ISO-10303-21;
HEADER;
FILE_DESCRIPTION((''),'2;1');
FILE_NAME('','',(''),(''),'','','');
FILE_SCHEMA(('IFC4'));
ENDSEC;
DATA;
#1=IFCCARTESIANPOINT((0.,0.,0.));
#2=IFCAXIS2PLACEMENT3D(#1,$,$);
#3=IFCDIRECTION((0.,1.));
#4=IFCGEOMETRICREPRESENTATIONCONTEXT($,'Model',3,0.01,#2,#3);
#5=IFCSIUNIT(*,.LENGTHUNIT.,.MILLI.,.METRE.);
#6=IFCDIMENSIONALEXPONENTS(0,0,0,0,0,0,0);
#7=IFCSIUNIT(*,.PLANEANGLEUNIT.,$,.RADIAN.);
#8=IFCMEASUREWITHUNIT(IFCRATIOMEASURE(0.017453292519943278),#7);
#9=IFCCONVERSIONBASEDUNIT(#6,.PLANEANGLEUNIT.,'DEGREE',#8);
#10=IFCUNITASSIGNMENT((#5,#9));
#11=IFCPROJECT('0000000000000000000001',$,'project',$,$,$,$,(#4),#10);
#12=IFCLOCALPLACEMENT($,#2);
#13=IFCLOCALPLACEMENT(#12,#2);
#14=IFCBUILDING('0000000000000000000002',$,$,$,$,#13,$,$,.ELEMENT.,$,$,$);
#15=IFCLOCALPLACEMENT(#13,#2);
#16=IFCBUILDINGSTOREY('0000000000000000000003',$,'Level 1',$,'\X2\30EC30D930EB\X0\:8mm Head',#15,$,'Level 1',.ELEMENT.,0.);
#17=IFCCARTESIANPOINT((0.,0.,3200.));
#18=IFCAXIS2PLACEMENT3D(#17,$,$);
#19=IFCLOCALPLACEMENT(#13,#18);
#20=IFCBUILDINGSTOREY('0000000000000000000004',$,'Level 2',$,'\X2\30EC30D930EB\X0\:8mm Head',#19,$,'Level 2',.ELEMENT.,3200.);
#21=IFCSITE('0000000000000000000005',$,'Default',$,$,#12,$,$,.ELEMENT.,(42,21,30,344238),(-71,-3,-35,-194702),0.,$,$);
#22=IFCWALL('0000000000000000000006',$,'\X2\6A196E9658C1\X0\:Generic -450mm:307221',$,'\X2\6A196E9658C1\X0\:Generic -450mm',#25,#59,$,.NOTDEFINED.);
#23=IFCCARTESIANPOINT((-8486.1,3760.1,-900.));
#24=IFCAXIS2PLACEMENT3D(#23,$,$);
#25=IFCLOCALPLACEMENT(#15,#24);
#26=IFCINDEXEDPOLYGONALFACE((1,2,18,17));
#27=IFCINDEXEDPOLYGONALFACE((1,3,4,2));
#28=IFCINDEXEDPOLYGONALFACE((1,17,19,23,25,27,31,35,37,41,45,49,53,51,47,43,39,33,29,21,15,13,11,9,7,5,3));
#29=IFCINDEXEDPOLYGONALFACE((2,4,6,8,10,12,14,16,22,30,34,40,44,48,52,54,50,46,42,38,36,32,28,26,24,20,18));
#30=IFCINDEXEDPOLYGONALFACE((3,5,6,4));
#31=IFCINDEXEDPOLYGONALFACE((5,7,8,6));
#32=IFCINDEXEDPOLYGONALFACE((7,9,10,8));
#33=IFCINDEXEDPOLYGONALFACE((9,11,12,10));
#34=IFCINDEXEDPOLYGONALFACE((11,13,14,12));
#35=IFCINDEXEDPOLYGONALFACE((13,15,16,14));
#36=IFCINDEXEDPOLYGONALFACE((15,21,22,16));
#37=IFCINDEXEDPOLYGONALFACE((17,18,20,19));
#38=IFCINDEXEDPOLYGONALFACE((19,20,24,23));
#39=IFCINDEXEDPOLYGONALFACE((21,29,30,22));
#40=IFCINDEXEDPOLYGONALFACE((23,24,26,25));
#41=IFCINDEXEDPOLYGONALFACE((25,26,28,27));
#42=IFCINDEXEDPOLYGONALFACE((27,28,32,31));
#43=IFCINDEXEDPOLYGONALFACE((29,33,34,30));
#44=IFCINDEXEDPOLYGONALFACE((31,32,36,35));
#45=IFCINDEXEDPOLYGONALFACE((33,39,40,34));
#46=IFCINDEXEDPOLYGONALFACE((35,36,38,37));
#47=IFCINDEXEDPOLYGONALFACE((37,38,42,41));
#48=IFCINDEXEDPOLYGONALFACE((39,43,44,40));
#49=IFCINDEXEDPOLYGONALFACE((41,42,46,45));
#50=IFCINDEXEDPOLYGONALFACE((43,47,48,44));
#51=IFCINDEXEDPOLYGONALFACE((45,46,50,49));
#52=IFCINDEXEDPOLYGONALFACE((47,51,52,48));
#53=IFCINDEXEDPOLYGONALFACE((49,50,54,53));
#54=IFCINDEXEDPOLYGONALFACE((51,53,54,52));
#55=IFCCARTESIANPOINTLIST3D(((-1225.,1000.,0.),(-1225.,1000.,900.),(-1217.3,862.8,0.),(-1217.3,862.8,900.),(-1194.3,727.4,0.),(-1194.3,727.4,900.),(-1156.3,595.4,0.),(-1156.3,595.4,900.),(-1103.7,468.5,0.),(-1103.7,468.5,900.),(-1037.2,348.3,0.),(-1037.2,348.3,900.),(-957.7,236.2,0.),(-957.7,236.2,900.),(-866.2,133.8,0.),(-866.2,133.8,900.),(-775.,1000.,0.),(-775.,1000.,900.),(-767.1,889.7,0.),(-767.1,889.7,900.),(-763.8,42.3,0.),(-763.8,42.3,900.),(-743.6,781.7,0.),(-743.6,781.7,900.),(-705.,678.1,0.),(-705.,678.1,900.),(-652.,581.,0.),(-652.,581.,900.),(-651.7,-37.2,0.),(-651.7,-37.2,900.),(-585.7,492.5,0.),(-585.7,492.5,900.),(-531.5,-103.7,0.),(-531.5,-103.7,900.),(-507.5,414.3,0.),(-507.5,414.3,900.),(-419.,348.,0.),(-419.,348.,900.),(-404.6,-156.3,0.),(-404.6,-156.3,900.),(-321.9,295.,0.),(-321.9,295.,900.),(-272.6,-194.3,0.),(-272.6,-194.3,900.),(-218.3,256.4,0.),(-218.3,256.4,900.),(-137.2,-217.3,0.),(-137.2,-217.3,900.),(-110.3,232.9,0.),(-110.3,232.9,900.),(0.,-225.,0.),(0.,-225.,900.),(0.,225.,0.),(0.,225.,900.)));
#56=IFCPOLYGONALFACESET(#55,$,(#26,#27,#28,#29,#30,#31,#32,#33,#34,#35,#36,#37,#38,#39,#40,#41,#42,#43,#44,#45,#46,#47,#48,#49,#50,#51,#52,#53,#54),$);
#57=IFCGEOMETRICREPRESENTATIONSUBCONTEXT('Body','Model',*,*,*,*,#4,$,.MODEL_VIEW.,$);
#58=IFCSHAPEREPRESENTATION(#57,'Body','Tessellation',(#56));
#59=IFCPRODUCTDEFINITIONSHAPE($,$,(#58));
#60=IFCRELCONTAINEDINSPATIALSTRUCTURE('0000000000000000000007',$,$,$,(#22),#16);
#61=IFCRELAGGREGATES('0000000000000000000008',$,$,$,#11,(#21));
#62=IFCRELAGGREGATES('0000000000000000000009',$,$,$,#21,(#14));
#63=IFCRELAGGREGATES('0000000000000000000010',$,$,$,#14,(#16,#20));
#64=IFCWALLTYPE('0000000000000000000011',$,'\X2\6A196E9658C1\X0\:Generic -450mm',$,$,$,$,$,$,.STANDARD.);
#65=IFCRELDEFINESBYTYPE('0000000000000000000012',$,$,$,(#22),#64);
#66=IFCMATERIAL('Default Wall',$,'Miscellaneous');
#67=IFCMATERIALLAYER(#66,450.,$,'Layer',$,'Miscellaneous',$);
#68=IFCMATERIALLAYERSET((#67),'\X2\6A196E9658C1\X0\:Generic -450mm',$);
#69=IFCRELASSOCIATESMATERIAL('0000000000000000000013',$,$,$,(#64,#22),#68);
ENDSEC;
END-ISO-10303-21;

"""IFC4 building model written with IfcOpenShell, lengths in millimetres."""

from ifc_helpers import new_model, entity, si_unit, converted_unit, direction, frame, frame_2d, origin, place, context, subcontext, project, spatial, polyline, circle_curve, parameter, trimmed, segment, composite_curve, outline, extrude, material, layer, layer_set, layer_usage, type_object, element, save


model = new_model("IFC4")

# Units and contexts
model_context = context("Model", 3, precision=0.01, world=origin(), true_north=direction((0.0, 1.0)))
body_context = subcontext(model_context, "Body", "Model", "MODEL_VIEW")
ifc_project = project(units=[si_unit("LENGTHUNIT", "METRE", prefix="MILLI"), converted_unit("PLANEANGLEUNIT", "DEGREE", entity("IfcRatioMeasure", 0.017453292519943278), si_unit("PLANEANGLEUNIT", "RADIAN"), dimensions=[0, 0, 0, 0, 0, 0, 0])], contexts=[model_context])

# Site, building, storey
site_placement = place(None, origin())
site = spatial("IfcSite", under=ifc_project, at=site_placement, Name="Default", CompositionType="ELEMENT", RefLatitude=(42, 21, 30, 344238), RefLongitude=(-71, -3, -35, -194702), RefElevation=0.0)
building_placement = place(site_placement, origin())
building = spatial("IfcBuilding", under=site, at=building_placement, CompositionType="ELEMENT")
storey_1_placement = place(building_placement, origin())
storey_1 = spatial("IfcBuildingStorey", under=building, at=storey_1_placement, Name="Level 1", ObjectType="レベル:8mm Head", LongName="Level 1", CompositionType="ELEMENT", Elevation=0.0)

# Shared definitions
ifc_material_1 = material(Name="Default Wall", Category="Miscellaneous")
ifc_layer_1 = layer(ifc_material_1, 450.0, Name="Layer", Category="Miscellaneous")
ifc_layer_set_1 = layer_set([ifc_layer_1], Name="標準壁:Generic -450mm")
wall_type_1 = type_object("IfcWallType", Name="標準壁:Generic -450mm", PredefinedType="STANDARD", material=ifc_layer_set_1)

# Shared definitions
storey_2_placement = place(building_placement, frame((0.0, 0.0, 3200.0)))
storey_2 = spatial("IfcBuildingStorey", under=building, at=storey_2_placement, Name="Level 2", ObjectType="レベル:8mm Head", LongName="Level 2", CompositionType="ELEMENT", Elevation=3200.0)

# Wall
ifc_layer_usage_1 = layer_usage(ifc_layer_set_1, "AXIS2", "POSITIVE", -225.0)
wall_1_placement = place(storey_1_placement, frame((-8486.1, 3760.1, -900.0)))
element("IfcWall", 1, at=wall_1_placement, inside=storey_1, type_object=wall_type_1, material=ifc_layer_usage_1, Name="標準壁:Generic -450mm:307221", ObjectType="標準壁:Generic -450mm", PredefinedType="NOTDEFINED", context=body_context, shape_type="SweptSolid", body=[
    extrude(outline(composite_curve([segment(trimmed(circle_curve(frame_2d((0.0, 1000.0), x_axis=(1.0, 0.0)), 1225.0), [parameter(180.0)], [parameter(270.0)], True, "PARAMETER"), True, "CONTINUOUS"), segment(polyline([(0.0, -225.0), (0.0, 225.0)]), True, "CONTINUOUS"), segment(trimmed(circle_curve(frame_2d((0.0, 1000.0), x_axis=(1.0, 0.0)), 775.0), [parameter(180.0)], [parameter(270.0)], True, "PARAMETER"), False, "CONTINUOUS"), segment(polyline([(-775.0, 1000.0), (-1225.0, 1000.0)]), True, "CONTINUOUS")], self_intersect=False)), origin(), (0.0, 0.0, 1.0), 900.0),
])

save(model, "model.ifc")
